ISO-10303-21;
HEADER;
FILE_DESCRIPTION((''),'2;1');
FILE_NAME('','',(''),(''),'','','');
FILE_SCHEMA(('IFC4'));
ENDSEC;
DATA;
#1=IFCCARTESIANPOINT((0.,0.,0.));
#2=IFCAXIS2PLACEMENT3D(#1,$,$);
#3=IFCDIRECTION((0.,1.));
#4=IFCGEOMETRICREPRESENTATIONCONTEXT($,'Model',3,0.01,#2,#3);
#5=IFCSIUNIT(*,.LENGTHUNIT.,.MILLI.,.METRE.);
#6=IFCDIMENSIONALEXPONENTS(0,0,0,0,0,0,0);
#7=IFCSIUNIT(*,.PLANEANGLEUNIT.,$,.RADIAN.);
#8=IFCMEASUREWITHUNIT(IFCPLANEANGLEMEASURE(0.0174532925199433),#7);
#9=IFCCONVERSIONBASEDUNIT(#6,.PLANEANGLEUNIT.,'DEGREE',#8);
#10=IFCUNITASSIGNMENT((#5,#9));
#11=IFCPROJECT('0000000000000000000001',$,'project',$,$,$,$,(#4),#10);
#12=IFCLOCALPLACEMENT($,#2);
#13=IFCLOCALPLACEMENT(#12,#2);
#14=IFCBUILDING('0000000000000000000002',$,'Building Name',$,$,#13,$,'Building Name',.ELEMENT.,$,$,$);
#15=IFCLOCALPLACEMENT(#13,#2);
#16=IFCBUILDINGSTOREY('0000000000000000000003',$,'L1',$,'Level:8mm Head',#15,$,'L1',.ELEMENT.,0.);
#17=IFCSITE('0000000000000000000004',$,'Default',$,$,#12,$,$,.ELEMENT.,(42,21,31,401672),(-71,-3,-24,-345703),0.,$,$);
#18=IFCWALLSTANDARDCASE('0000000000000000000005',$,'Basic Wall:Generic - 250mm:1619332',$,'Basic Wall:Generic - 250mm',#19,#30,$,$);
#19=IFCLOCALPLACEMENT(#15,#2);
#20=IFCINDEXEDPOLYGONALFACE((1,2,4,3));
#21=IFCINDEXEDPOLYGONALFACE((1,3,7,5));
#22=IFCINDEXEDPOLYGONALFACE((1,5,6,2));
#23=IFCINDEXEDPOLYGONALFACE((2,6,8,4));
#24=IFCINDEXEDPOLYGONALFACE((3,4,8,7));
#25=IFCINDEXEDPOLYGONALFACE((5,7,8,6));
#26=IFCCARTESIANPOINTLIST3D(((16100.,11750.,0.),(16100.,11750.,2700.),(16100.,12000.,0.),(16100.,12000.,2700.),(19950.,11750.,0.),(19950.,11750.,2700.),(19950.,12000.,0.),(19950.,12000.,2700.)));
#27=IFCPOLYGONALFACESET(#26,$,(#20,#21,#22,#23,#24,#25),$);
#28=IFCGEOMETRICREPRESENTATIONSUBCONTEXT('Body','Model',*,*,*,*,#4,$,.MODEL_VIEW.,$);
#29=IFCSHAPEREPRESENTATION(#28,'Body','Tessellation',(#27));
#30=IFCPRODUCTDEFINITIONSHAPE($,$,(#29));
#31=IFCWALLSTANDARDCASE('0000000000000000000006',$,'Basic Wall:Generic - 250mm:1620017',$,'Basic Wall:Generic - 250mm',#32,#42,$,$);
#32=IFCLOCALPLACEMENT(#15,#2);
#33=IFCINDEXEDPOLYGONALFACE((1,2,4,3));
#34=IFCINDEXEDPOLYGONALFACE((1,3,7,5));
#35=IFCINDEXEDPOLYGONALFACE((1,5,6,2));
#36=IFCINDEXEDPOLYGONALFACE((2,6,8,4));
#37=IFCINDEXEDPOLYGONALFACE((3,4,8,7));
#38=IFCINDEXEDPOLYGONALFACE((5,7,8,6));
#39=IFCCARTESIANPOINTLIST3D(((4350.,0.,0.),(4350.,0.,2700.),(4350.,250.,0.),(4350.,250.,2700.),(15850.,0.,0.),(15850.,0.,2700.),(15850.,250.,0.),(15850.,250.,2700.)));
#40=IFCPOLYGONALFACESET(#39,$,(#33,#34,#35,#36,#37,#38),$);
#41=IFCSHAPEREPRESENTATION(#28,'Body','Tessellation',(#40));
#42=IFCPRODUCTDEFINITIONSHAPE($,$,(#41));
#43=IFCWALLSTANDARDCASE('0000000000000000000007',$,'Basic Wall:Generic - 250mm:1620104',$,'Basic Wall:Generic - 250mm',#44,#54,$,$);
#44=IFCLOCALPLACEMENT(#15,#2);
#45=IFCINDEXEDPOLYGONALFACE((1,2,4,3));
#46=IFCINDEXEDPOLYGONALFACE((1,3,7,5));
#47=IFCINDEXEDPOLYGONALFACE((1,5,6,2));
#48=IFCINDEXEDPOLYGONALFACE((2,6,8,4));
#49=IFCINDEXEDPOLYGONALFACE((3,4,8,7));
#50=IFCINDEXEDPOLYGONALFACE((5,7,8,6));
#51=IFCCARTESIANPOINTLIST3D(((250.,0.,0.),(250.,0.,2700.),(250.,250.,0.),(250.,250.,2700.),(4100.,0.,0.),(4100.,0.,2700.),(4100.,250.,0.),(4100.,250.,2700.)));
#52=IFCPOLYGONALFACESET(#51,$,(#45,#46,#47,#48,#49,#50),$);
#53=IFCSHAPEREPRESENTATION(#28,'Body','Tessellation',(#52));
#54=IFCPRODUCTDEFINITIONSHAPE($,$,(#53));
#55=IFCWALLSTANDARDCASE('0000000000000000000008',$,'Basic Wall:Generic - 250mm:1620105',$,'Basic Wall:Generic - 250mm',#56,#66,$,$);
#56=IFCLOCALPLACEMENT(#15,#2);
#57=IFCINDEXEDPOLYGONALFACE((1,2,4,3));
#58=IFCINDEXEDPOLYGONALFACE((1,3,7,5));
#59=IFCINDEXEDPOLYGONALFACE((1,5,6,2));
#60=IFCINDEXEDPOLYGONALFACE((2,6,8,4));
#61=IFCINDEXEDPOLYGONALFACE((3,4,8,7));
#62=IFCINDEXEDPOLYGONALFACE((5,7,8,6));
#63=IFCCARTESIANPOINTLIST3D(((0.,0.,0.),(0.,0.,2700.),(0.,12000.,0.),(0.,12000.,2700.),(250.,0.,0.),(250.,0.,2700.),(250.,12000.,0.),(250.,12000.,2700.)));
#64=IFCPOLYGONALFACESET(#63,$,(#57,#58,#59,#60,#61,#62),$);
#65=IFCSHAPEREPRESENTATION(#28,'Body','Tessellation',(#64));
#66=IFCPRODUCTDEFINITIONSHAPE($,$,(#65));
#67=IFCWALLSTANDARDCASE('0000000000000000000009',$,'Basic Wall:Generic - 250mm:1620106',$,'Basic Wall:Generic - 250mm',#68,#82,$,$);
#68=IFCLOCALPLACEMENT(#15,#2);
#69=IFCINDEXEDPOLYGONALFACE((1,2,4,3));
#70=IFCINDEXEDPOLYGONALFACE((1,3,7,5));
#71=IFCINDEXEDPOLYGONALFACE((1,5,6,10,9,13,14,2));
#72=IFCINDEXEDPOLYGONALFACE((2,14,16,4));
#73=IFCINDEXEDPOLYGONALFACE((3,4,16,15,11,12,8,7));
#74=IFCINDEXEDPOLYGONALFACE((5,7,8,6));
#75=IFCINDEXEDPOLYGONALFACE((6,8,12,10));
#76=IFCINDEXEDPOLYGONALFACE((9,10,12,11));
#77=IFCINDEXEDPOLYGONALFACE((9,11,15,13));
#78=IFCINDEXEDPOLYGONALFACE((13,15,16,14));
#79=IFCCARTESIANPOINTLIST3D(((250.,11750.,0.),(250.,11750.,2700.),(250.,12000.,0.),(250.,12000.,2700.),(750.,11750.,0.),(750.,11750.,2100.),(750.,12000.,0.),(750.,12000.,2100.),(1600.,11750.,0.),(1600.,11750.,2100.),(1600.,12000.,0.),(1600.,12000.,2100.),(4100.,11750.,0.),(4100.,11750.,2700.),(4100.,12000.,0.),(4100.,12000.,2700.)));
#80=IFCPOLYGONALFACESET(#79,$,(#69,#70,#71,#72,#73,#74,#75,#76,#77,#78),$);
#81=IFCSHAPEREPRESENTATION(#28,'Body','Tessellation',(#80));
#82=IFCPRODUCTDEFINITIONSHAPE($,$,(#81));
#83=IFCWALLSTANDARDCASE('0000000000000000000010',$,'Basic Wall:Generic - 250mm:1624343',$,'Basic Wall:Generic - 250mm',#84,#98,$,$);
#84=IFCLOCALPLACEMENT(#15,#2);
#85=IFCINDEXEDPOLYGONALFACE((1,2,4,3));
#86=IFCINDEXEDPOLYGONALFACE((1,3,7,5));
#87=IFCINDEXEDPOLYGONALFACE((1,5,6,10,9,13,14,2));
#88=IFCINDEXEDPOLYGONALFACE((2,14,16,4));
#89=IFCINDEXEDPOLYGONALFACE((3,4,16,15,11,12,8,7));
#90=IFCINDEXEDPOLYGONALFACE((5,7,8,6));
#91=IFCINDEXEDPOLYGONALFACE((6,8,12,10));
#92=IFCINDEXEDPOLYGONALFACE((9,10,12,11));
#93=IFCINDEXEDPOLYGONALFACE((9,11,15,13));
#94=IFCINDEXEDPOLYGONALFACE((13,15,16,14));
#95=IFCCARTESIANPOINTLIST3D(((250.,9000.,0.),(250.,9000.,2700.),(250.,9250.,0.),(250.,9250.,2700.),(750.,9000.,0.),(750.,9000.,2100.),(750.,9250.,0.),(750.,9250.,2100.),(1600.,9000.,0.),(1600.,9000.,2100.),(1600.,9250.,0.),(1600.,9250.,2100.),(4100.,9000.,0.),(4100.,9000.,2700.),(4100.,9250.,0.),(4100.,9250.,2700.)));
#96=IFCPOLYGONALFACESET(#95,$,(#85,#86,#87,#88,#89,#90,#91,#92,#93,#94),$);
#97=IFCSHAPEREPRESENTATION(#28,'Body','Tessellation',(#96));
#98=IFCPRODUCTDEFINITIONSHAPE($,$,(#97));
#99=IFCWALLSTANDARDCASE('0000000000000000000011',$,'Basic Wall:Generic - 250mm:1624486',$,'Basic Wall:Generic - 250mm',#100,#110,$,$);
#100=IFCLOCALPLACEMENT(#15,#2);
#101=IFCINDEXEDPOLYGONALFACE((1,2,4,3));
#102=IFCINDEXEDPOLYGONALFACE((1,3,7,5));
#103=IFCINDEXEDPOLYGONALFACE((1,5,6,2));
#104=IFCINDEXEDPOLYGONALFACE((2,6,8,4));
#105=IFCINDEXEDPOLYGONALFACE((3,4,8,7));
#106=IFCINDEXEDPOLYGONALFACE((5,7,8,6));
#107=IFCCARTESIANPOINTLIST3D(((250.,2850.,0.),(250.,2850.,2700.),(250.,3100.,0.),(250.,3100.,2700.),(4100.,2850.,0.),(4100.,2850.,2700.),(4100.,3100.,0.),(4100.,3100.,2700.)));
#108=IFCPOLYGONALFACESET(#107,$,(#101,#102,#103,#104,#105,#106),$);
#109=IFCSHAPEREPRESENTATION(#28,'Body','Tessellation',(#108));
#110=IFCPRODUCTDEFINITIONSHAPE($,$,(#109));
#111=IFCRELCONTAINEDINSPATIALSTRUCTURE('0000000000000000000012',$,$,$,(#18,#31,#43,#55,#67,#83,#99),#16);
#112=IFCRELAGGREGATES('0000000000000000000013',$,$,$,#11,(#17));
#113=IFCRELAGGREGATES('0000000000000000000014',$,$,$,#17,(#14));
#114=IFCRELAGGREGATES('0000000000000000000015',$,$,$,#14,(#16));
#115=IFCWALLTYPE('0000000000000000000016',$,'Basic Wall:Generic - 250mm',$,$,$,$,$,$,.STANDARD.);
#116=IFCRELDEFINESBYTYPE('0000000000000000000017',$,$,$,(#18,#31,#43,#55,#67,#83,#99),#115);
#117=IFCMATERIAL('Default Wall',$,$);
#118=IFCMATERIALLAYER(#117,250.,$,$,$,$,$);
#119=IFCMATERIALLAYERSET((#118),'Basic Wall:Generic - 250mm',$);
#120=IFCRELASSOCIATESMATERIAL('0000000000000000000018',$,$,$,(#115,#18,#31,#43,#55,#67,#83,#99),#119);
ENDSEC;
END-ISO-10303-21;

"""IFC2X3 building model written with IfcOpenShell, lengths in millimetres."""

from ifc_helpers import new_model, entity, si_unit, converted_unit, direction, frame, frame_2d, origin, place, context, subcontext, project, spatial, rectangle, extrude, material, layer, layer_set, layer_usage, type_object, element, save


model = new_model("IFC2X3")

# Units and contexts
model_context = context("Model", 3, precision=0.01, world=origin(), true_north=direction((0.0, 1.0)))
body_context = subcontext(model_context, "Body", "Model", "MODEL_VIEW")
ifc_project = project(units=[si_unit("LENGTHUNIT", "METRE", prefix="MILLI"), converted_unit("PLANEANGLEUNIT", "DEGREE", entity("IfcPlaneAngleMeasure", 0.0174532925199433), si_unit("PLANEANGLEUNIT", "RADIAN"), dimensions=[0, 0, 0, 0, 0, 0, 0])], contexts=[model_context])

# Site, building, storey
site_placement = place(None, origin())
site = spatial("IfcSite", under=ifc_project, at=site_placement, Name="Default", CompositionType="ELEMENT", RefLatitude=(42, 21, 31, 401672), RefLongitude=(-71, -3, -24, -345703), RefElevation=0.0)
building_placement = place(site_placement, origin())
building = spatial("IfcBuilding", under=site, at=building_placement, Name="Building Name", LongName="Building Name", CompositionType="ELEMENT")
storey_placement = place(building_placement, origin())
storey = spatial("IfcBuildingStorey", under=building, at=storey_placement, Name="L1", ObjectType="Level:8mm Head", LongName="L1", CompositionType="ELEMENT", Elevation=0.0)

# Shared definitions
ifc_material_1 = material(Name="Default Wall")
ifc_layer_1 = layer(ifc_material_1, 250.0)
ifc_layer_set_1 = layer_set([ifc_layer_1], Name="Basic Wall:Generic - 250mm")
wall_type = type_object("IfcWallType", Name="Basic Wall:Generic - 250mm", PredefinedType="STANDARD", material=ifc_layer_set_1)

# Walls
ifc_layer_usage_1 = layer_usage(ifc_layer_set_1, "AXIS2", "NEGATIVE", 125.0)
wall_1_placement = place(storey_placement, frame((19950.0, 11875.0, 0.0), z_axis=(0.0, 0.0, 1.0), x_axis=(-1.0, 0.0, 0.0)))
element("IfcWallStandardCase", 1, at=wall_1_placement, inside=storey, type_object=wall_type, material=ifc_layer_usage_1, Name="Basic Wall:Generic - 250mm:1619332", ObjectType="Basic Wall:Generic - 250mm", context=body_context, shape_type="SweptSolid", body=[
    extrude(rectangle(XDim=3850.0, YDim=250.0, at=frame_2d((1925.0, 0.0), x_axis=(-1.0, 0.0))), origin(), (0.0, 0.0, 1.0), 2700.0),
])
ifc_layer_usage_2 = layer_usage(ifc_layer_set_1, "AXIS2", "NEGATIVE", 125.0)
wall_2_placement = place(storey_placement, frame((4350.0, 125.0, 0.0)))
element("IfcWallStandardCase", 2, at=wall_2_placement, inside=storey, type_object=wall_type, material=ifc_layer_usage_2, Name="Basic Wall:Generic - 250mm:1620017", ObjectType="Basic Wall:Generic - 250mm", context=body_context, shape_type="SweptSolid", body=[
    extrude(rectangle(XDim=11500.0, YDim=250.0, at=frame_2d((5750.0, 0.0), x_axis=(-1.0, 0.0))), origin(), (0.0, 0.0, 1.0), 2700.0),
])
ifc_layer_usage_3 = layer_usage(ifc_layer_set_1, "AXIS2", "POSITIVE", -125.0)
wall_3_placement = place(storey_placement, frame((4100.0, 125.0, 0.0), z_axis=(0.0, 0.0, 1.0), x_axis=(-1.0, 0.0, 0.0)))
element("IfcWallStandardCase", 3, at=wall_3_placement, inside=storey, type_object=wall_type, material=ifc_layer_usage_3, Name="Basic Wall:Generic - 250mm:1620104", ObjectType="Basic Wall:Generic - 250mm", context=body_context, shape_type="SweptSolid", body=[
    extrude(rectangle(XDim=3850.0, YDim=250.0, at=frame_2d((1925.0, 0.0), x_axis=(-1.0, 0.0))), origin(), (0.0, 0.0, 1.0), 2700.0),
])
ifc_layer_usage_4 = layer_usage(ifc_layer_set_1, "AXIS2", "POSITIVE", -125.0)
wall_4_placement = place(storey_placement, frame((125.0, 0.0, 0.0), z_axis=(0.0, 0.0, 1.0), x_axis=(0.0, 1.0, 0.0)))
element("IfcWallStandardCase", 4, at=wall_4_placement, inside=storey, type_object=wall_type, material=ifc_layer_usage_4, Name="Basic Wall:Generic - 250mm:1620105", ObjectType="Basic Wall:Generic - 250mm", context=body_context, shape_type="SweptSolid", body=[
    extrude(rectangle(XDim=12000.0, YDim=250.0, at=frame_2d((6000.0, 0.0), x_axis=(-1.0, 0.0))), origin(), (0.0, 0.0, 1.0), 2700.0),
])

# Walls, openings
ifc_layer_usage_5 = layer_usage(ifc_layer_set_1, "AXIS2", "POSITIVE", -125.0)
wall_5_placement = place(storey_placement, frame((250.0, 11875.0, 0.0)))
wall_5 = element("IfcWallStandardCase", 5, at=wall_5_placement, inside=storey, type_object=wall_type, material=ifc_layer_usage_5, Name="Basic Wall:Generic - 250mm:1620106", ObjectType="Basic Wall:Generic - 250mm", context=body_context, shape_type="SweptSolid", body=[
    extrude(rectangle(XDim=3850.0, YDim=250.0, at=frame_2d((1925.0, 0.0), x_axis=(-1.0, 0.0))), origin(), (0.0, 0.0, 1.0), 2700.0),
])
opening_1_placement = place(wall_5_placement, frame((1350.0, 125.0, 0.0)))
element("IfcOpeningElement", 6, at=opening_1_placement, cuts=wall_5, ObjectType="Opening", context=body_context, shape_type="SweptSolid", body=[
    extrude(rectangle(XDim=2100.0, YDim=850.0, at=frame_2d((1050.0, 425.0), x_axis=(1.0, 0.0))), frame((0.0, 0.0, 0.0), z_axis=(0.0, -1.0, 0.0), x_axis=(0.0, 0.0, 1.0)), (0.0, 0.0, 1.0), 250.0),
])
ifc_layer_usage_6 = layer_usage(ifc_layer_set_1, "AXIS2", "NEGATIVE", 125.0)
wall_6_placement = place(storey_placement, frame((250.0, 9125.0, 0.0)))
wall_6 = element("IfcWallStandardCase", 7, at=wall_6_placement, inside=storey, type_object=wall_type, material=ifc_layer_usage_6, Name="Basic Wall:Generic - 250mm:1624343", ObjectType="Basic Wall:Generic - 250mm", context=body_context, shape_type="SweptSolid", body=[
    extrude(rectangle(XDim=3850.0, YDim=250.0, at=frame_2d((1925.0, 0.0), x_axis=(-1.0, 0.0))), origin(), (0.0, 0.0, 1.0), 2700.0),
])
opening_2_placement = place(wall_6_placement, frame((1350.0, 125.0, 0.0)))
element("IfcOpeningElement", 8, at=opening_2_placement, cuts=wall_6, ObjectType="Opening", context=body_context, shape_type="SweptSolid", body=[
    extrude(rectangle(XDim=2100.0, YDim=850.0, at=frame_2d((1050.0, 425.0), x_axis=(1.0, 0.0))), frame((0.0, 0.0, 0.0), z_axis=(0.0, -1.0, 0.0), x_axis=(0.0, 0.0, 1.0)), (0.0, 0.0, 1.0), 250.0),
])

# Wall
ifc_layer_usage_7 = layer_usage(ifc_layer_set_1, "AXIS2", "POSITIVE", -125.0)
wall_7_placement = place(storey_placement, frame((4100.0, 2975.0, 0.0), z_axis=(0.0, 0.0, 1.0), x_axis=(-1.0, 0.0, 0.0)))
element("IfcWallStandardCase", 9, at=wall_7_placement, inside=storey, type_object=wall_type, material=ifc_layer_usage_7, Name="Basic Wall:Generic - 250mm:1624486", ObjectType="Basic Wall:Generic - 250mm", context=body_context, shape_type="SweptSolid", body=[
    extrude(rectangle(XDim=3850.0, YDim=250.0, at=frame_2d((1925.0, 0.0), x_axis=(-1.0, 0.0))), origin(), (0.0, 0.0, 1.0), 2700.0),
])

save(model, "model.ifc")
